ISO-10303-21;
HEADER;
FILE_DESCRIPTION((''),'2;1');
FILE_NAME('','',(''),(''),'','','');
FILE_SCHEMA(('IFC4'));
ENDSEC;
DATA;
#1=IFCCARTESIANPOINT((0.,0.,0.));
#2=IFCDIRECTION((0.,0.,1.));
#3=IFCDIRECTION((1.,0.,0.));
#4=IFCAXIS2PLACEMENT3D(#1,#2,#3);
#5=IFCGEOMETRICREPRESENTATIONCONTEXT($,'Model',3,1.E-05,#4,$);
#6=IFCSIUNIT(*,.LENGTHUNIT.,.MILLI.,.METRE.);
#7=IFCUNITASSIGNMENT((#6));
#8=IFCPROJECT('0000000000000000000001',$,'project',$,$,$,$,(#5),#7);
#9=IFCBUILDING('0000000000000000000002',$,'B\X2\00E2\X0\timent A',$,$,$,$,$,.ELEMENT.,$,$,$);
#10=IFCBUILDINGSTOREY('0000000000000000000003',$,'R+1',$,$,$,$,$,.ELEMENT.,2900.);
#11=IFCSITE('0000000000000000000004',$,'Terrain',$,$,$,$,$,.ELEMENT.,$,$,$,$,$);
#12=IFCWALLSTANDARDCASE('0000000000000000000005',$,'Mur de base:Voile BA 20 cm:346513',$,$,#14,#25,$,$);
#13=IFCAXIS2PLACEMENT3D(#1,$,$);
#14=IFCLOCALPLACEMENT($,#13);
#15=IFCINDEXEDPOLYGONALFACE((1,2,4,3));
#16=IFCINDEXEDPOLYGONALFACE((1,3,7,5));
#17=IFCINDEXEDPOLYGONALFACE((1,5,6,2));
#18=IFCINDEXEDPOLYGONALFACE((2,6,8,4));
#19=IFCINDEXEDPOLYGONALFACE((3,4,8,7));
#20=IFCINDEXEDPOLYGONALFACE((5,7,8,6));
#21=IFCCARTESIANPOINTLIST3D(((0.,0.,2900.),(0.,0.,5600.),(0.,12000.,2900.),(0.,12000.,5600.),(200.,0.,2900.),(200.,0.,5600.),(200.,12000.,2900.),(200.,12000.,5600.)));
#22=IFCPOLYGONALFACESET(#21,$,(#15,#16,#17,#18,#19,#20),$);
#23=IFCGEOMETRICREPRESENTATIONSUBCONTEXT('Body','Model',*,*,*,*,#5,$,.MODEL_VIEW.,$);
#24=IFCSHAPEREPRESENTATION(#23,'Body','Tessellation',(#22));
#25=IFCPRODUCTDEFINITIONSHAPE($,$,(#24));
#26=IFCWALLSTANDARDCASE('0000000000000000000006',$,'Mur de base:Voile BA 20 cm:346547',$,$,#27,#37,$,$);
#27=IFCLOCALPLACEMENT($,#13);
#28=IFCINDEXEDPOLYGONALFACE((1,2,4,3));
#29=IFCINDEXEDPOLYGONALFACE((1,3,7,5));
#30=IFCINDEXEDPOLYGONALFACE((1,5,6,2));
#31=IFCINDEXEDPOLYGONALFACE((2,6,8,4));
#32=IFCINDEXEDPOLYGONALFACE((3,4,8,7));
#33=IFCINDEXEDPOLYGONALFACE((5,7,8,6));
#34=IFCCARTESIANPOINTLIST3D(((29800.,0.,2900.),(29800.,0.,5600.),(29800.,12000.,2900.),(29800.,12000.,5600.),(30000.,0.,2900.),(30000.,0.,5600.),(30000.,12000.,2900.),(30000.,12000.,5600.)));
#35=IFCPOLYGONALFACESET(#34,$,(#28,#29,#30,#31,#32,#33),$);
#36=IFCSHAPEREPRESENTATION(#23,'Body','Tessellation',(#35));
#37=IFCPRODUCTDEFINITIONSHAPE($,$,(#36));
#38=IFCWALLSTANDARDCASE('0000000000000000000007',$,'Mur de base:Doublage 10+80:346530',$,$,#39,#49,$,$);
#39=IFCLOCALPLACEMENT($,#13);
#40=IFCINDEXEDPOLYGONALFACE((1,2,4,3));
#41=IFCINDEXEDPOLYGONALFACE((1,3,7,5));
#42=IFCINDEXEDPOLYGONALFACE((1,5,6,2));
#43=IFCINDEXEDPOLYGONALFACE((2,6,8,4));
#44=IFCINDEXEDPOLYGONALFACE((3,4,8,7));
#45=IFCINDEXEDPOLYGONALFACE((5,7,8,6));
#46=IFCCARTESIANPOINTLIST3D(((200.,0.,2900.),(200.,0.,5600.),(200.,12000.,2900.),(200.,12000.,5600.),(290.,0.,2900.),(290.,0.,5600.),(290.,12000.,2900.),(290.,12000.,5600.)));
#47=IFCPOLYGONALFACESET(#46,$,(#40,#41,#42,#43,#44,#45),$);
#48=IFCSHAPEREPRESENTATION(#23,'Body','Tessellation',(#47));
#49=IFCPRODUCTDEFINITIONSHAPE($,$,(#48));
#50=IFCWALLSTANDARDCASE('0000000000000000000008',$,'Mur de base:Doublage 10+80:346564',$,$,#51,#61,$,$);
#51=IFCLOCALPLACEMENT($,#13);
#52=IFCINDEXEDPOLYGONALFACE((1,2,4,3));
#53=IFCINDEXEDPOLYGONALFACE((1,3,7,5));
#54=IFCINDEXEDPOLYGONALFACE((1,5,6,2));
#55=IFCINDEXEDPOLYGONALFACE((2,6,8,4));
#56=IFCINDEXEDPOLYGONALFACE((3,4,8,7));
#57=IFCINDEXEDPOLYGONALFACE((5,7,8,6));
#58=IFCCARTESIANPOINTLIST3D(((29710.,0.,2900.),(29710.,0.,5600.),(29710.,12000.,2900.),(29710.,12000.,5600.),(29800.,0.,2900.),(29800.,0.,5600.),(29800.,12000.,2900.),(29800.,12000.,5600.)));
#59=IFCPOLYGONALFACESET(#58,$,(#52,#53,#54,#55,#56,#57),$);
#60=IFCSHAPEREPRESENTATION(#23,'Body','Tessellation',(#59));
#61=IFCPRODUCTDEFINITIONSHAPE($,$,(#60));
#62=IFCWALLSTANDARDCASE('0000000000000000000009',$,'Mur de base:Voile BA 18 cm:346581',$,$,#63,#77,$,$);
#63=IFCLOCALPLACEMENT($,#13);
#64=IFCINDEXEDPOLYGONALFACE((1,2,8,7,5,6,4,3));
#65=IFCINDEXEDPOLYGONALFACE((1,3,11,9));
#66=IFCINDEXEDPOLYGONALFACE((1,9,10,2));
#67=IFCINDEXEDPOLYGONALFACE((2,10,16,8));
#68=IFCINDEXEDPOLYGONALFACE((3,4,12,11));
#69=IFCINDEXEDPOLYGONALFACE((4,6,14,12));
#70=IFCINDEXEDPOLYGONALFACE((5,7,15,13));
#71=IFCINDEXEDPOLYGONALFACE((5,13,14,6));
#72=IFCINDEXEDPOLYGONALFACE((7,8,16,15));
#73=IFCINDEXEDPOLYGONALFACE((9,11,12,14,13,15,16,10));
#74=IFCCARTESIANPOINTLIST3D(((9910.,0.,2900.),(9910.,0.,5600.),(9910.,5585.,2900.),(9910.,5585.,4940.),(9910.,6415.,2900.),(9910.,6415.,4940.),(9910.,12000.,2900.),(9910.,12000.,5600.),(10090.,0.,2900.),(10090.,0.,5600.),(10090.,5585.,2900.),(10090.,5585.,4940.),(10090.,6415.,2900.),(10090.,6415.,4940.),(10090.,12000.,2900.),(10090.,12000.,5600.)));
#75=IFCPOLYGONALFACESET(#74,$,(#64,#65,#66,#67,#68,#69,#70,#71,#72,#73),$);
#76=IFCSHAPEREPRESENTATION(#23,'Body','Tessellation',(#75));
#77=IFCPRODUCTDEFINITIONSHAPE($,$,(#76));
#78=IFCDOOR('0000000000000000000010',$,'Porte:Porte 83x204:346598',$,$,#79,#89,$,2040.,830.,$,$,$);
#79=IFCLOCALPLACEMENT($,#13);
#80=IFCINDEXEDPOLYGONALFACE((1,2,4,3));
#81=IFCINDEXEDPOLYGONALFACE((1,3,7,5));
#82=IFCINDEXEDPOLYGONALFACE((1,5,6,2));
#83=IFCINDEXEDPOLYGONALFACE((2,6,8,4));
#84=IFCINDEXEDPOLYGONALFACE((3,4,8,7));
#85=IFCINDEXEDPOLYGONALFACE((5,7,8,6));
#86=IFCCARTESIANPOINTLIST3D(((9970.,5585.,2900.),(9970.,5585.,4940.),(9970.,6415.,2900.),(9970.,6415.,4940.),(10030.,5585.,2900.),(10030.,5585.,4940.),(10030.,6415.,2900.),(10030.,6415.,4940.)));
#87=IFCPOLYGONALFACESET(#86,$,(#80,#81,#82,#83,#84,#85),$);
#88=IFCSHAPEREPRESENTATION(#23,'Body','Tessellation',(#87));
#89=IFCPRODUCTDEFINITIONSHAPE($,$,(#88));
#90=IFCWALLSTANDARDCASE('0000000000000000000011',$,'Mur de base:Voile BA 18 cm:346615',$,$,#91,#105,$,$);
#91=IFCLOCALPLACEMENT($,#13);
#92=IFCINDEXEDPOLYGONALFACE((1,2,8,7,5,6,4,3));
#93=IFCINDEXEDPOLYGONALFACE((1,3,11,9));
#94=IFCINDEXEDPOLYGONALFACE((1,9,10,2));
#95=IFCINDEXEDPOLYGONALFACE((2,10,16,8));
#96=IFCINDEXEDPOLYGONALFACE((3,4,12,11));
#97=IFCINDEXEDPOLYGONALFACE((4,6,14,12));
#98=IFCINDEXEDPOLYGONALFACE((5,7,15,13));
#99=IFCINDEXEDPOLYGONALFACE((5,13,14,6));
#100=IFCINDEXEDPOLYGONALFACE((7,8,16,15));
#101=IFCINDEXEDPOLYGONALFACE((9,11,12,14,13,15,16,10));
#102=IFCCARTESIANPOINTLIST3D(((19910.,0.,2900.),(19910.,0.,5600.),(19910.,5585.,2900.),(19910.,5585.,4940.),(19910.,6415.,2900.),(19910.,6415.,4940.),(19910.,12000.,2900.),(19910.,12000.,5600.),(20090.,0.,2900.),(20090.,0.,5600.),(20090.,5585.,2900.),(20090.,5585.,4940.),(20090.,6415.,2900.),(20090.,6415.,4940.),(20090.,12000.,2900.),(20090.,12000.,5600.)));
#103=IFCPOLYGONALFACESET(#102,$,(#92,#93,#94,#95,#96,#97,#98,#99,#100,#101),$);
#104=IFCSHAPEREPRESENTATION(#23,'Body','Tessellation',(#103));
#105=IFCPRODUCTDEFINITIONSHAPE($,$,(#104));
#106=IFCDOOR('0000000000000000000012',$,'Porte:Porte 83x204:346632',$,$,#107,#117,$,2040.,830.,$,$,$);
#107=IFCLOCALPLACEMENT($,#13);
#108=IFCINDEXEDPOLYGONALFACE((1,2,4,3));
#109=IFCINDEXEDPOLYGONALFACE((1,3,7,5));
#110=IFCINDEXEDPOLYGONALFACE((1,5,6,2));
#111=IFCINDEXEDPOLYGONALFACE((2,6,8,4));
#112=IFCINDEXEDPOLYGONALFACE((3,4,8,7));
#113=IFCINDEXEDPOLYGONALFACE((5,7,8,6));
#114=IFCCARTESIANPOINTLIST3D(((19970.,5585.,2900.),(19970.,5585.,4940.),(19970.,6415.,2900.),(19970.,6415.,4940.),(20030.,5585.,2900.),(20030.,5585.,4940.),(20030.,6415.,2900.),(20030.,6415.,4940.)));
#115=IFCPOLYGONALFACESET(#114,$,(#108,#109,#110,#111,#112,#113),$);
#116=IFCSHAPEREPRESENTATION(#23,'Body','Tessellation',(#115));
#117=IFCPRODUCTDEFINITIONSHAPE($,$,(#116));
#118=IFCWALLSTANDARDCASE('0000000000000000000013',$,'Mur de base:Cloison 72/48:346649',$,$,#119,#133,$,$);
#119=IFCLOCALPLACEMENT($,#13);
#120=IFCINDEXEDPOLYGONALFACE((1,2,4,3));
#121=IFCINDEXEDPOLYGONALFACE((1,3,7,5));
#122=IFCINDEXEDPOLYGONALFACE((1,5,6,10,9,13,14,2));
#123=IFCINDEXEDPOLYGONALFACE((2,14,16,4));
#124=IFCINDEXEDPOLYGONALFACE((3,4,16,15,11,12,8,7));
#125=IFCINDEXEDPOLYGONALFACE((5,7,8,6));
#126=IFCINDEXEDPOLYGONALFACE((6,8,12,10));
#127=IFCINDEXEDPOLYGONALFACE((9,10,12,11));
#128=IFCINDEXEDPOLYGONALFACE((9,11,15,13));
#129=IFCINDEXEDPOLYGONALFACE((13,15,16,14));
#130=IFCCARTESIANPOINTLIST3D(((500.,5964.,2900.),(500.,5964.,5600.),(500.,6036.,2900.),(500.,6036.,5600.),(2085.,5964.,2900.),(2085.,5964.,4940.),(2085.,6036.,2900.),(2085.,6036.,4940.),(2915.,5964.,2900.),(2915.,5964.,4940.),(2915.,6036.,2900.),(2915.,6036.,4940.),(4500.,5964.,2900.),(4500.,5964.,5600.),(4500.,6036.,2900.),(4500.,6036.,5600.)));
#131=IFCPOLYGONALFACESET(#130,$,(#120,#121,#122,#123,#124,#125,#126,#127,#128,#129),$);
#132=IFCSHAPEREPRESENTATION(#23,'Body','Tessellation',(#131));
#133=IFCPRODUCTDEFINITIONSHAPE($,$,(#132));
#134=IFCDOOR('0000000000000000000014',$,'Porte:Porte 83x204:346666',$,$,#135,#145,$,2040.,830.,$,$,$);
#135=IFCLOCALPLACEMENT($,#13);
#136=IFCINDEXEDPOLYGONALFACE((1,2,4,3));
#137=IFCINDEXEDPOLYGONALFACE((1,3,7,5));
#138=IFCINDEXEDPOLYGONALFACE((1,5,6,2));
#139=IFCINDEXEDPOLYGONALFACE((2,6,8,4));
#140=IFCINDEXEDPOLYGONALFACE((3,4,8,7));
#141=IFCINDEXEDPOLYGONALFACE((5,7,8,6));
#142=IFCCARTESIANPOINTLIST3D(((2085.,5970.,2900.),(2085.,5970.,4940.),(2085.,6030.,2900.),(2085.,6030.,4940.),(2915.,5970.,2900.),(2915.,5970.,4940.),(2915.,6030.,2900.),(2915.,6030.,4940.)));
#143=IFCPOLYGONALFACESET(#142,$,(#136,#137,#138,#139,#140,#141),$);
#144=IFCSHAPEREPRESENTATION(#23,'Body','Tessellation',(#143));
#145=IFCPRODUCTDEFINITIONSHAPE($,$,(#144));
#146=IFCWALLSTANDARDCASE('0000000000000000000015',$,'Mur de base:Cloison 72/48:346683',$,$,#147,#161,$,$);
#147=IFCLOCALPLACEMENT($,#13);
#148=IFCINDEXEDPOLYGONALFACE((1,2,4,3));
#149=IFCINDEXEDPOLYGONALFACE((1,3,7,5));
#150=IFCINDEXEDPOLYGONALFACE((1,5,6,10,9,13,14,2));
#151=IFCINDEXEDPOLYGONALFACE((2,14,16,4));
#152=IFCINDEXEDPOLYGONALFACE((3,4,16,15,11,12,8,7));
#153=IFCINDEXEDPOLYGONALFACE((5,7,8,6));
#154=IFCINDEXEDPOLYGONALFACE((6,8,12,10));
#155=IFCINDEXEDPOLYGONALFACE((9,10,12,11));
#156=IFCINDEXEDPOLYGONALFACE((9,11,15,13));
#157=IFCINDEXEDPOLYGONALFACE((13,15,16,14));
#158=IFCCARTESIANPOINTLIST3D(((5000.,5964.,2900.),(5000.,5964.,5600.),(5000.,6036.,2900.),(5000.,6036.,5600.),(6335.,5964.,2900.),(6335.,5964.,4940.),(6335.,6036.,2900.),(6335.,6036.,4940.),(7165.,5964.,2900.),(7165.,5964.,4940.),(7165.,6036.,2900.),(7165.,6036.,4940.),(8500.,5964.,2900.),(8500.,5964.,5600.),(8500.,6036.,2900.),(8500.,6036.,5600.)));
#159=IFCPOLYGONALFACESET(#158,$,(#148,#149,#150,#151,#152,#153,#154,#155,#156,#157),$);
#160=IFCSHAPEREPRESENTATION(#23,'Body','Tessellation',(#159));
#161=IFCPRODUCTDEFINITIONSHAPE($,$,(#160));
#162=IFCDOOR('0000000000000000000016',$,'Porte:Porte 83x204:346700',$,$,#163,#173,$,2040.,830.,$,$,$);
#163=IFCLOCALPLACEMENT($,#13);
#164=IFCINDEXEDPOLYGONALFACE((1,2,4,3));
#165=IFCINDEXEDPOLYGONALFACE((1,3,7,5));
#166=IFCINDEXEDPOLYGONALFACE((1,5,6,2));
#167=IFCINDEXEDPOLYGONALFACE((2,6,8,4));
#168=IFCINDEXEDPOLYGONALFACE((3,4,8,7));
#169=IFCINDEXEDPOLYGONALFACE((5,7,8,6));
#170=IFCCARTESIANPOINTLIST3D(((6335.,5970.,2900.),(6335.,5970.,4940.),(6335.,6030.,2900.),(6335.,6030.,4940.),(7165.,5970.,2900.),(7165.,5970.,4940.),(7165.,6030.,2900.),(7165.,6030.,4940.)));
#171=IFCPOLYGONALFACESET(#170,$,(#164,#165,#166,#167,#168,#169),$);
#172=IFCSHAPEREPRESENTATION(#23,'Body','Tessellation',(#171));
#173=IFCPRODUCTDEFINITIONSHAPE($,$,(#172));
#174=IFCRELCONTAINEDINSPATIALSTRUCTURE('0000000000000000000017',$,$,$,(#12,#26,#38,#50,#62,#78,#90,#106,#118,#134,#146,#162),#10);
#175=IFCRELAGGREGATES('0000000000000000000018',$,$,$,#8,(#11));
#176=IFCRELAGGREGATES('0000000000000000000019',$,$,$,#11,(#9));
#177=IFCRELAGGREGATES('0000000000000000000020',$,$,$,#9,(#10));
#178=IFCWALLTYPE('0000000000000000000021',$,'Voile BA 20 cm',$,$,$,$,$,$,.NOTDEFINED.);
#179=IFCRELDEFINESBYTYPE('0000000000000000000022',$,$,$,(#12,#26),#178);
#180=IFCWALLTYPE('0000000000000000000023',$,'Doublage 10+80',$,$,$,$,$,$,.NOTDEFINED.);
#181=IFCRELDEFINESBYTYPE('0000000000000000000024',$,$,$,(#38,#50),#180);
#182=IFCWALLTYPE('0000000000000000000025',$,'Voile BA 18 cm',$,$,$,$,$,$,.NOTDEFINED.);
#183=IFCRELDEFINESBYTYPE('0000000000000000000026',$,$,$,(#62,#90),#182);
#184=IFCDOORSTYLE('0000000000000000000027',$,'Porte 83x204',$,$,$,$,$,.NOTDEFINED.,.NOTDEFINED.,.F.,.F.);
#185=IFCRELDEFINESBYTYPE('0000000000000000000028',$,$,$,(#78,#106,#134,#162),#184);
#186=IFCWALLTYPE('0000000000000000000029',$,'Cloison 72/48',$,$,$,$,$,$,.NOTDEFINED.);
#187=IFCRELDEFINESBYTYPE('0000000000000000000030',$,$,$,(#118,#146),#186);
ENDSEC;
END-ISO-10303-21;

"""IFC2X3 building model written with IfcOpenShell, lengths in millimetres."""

from ifc_helpers import new_model, si_unit, frame, frame_2d, origin_with_axes, place, context, subcontext, project, spatial, rectangle, extrude, type_object, element, fill, save


model = new_model("IFC2X3")

# Units and contexts
model_context = context("Model", 3, precision=1e-05, world=origin_with_axes())
body_context = subcontext(model_context, "Body", "Model", "MODEL_VIEW")
ifc_project = project(units=[si_unit("LENGTHUNIT", "METRE", prefix="MILLI")], contexts=[model_context])

# Site, building, storey
site = spatial("IfcSite", under=ifc_project, Name="Terrain", CompositionType="ELEMENT")
building = spatial("IfcBuilding", under=site, Name="Bâtiment A", CompositionType="ELEMENT")
storey = spatial("IfcBuildingStorey", under=building, Name="R+1", CompositionType="ELEMENT", Elevation=2900.0)

# Walls
wall_type_1 = type_object("IfcWallType", Name="Voile BA 20 cm", PredefinedType="NOTDEFINED")
wall_1_placement = place(None, origin_with_axes())
element("IfcWallStandardCase", 1, at=wall_1_placement, inside=storey, type_object=wall_type_1, Name="Mur de base:Voile BA 20 cm:346513", context=body_context, shape_type="SweptSolid", body=[
    extrude(rectangle(XDim=200.0, YDim=12000.0, at=frame_2d((100.0, 6000.0))), frame((0.0, 0.0, 2900.0), z_axis=(0.0, 0.0, 1.0), x_axis=(1.0, 0.0, 0.0)), (0.0, 0.0, 1.0), 2700.0),
])
wall_2_placement = place(None, origin_with_axes())
element("IfcWallStandardCase", 2, at=wall_2_placement, inside=storey, type_object=wall_type_1, Name="Mur de base:Voile BA 20 cm:346547", context=body_context, shape_type="SweptSolid", body=[
    extrude(rectangle(XDim=200.0, YDim=12000.0, at=frame_2d((29900.0, 6000.0))), frame((0.0, 0.0, 2900.0), z_axis=(0.0, 0.0, 1.0), x_axis=(1.0, 0.0, 0.0)), (0.0, 0.0, 1.0), 2700.0),
])
wall_type_2 = type_object("IfcWallType", Name="Doublage 10+80", PredefinedType="NOTDEFINED")
wall_3_placement = place(None, origin_with_axes())
element("IfcWallStandardCase", 3, at=wall_3_placement, inside=storey, type_object=wall_type_2, Name="Mur de base:Doublage 10+80:346530", context=body_context, shape_type="SweptSolid", body=[
    extrude(rectangle(XDim=90.0, YDim=12000.0, at=frame_2d((245.0, 6000.0))), frame((0.0, 0.0, 2900.0), z_axis=(0.0, 0.0, 1.0), x_axis=(1.0, 0.0, 0.0)), (0.0, 0.0, 1.0), 2700.0),
])
wall_4_placement = place(None, origin_with_axes())
element("IfcWallStandardCase", 4, at=wall_4_placement, inside=storey, type_object=wall_type_2, Name="Mur de base:Doublage 10+80:346564", context=body_context, shape_type="SweptSolid", body=[
    extrude(rectangle(XDim=90.0, YDim=12000.0, at=frame_2d((29755.0, 6000.0))), frame((0.0, 0.0, 2900.0), z_axis=(0.0, 0.0, 1.0), x_axis=(1.0, 0.0, 0.0)), (0.0, 0.0, 1.0), 2700.0),
])

# Walls, openings, doors
wall_type_3 = type_object("IfcWallType", Name="Voile BA 18 cm", PredefinedType="NOTDEFINED")
wall_5_placement = place(None, origin_with_axes())
wall_5 = element("IfcWallStandardCase", 5, at=wall_5_placement, inside=storey, type_object=wall_type_3, Name="Mur de base:Voile BA 18 cm:346581", context=body_context, shape_type="SweptSolid", body=[
    extrude(rectangle(XDim=180.0, YDim=12000.0, at=frame_2d((10000.0, 6000.0))), frame((0.0, 0.0, 2900.0), z_axis=(0.0, 0.0, 1.0), x_axis=(1.0, 0.0, 0.0)), (0.0, 0.0, 1.0), 2700.0),
])
opening_1_placement = place(None, origin_with_axes())
opening_1 = element("IfcOpeningElement", 6, at=opening_1_placement, cuts=wall_5, context=body_context, shape_type="SweptSolid", body=[
    extrude(rectangle(XDim=300.0, YDim=830.0, at=frame_2d((10000.0, 6000.0))), frame((0.0, 0.0, 2900.0), z_axis=(0.0, 0.0, 1.0), x_axis=(1.0, 0.0, 0.0)), (0.0, 0.0, 1.0), 2040.0),
])
door_style = type_object("IfcDoorStyle", Name="Porte 83x204", ConstructionType="NOTDEFINED", OperationType="NOTDEFINED", ParameterTakesPrecedence=False, Sizeable=False)
door_1_placement = place(None, origin_with_axes())
door_1 = element("IfcDoor", 7, at=door_1_placement, inside=storey, type_object=door_style, Name="Porte:Porte 83x204:346598", OverallHeight=2040.0, OverallWidth=830.0, context=body_context, shape_type="SweptSolid", body=[
    extrude(rectangle(XDim=60.0, YDim=830.0, at=frame_2d((10000.0, 6000.0))), frame((0.0, 0.0, 2900.0), z_axis=(0.0, 0.0, 1.0), x_axis=(1.0, 0.0, 0.0)), (0.0, 0.0, 1.0), 2040.0),
])
fill(opening_1, door_1)
wall_6_placement = place(None, origin_with_axes())
wall_6 = element("IfcWallStandardCase", 8, at=wall_6_placement, inside=storey, type_object=wall_type_3, Name="Mur de base:Voile BA 18 cm:346615", context=body_context, shape_type="SweptSolid", body=[
    extrude(rectangle(XDim=180.0, YDim=12000.0, at=frame_2d((20000.0, 6000.0))), frame((0.0, 0.0, 2900.0), z_axis=(0.0, 0.0, 1.0), x_axis=(1.0, 0.0, 0.0)), (0.0, 0.0, 1.0), 2700.0),
])
opening_2_placement = place(None, origin_with_axes())
opening_2 = element("IfcOpeningElement", 9, at=opening_2_placement, cuts=wall_6, context=body_context, shape_type="SweptSolid", body=[
    extrude(rectangle(XDim=300.0, YDim=830.0, at=frame_2d((20000.0, 6000.0))), frame((0.0, 0.0, 2900.0), z_axis=(0.0, 0.0, 1.0), x_axis=(1.0, 0.0, 0.0)), (0.0, 0.0, 1.0), 2040.0),
])
door_2_placement = place(None, origin_with_axes())
door_2 = element("IfcDoor", 10, at=door_2_placement, inside=storey, type_object=door_style, Name="Porte:Porte 83x204:346632", OverallHeight=2040.0, OverallWidth=830.0, context=body_context, shape_type="SweptSolid", body=[
    extrude(rectangle(XDim=60.0, YDim=830.0, at=frame_2d((20000.0, 6000.0))), frame((0.0, 0.0, 2900.0), z_axis=(0.0, 0.0, 1.0), x_axis=(1.0, 0.0, 0.0)), (0.0, 0.0, 1.0), 2040.0),
])
fill(opening_2, door_2)
wall_type_4 = type_object("IfcWallType", Name="Cloison 72/48", PredefinedType="NOTDEFINED")
wall_7_placement = place(None, origin_with_axes())
wall_7 = element("IfcWallStandardCase", 11, at=wall_7_placement, inside=storey, type_object=wall_type_4, Name="Mur de base:Cloison 72/48:346649", context=body_context, shape_type="SweptSolid", body=[
    extrude(rectangle(XDim=4000.0, YDim=72.0, at=frame_2d((2500.0, 6000.0))), frame((0.0, 0.0, 2900.0), z_axis=(0.0, 0.0, 1.0), x_axis=(1.0, 0.0, 0.0)), (0.0, 0.0, 1.0), 2700.0),
])
opening_3_placement = place(None, origin_with_axes())
opening_3 = element("IfcOpeningElement", 12, at=opening_3_placement, cuts=wall_7, context=body_context, shape_type="SweptSolid", body=[
    extrude(rectangle(XDim=830.0, YDim=192.0, at=frame_2d((2500.0, 6000.0))), frame((0.0, 0.0, 2900.0), z_axis=(0.0, 0.0, 1.0), x_axis=(1.0, 0.0, 0.0)), (0.0, 0.0, 1.0), 2040.0),
])
door_3_placement = place(None, origin_with_axes())
door_3 = element("IfcDoor", 13, at=door_3_placement, inside=storey, type_object=door_style, Name="Porte:Porte 83x204:346666", OverallHeight=2040.0, OverallWidth=830.0, context=body_context, shape_type="SweptSolid", body=[
    extrude(rectangle(XDim=830.0, YDim=60.0, at=frame_2d((2500.0, 6000.0))), frame((0.0, 0.0, 2900.0), z_axis=(0.0, 0.0, 1.0), x_axis=(1.0, 0.0, 0.0)), (0.0, 0.0, 1.0), 2040.0),
])
fill(opening_3, door_3)
wall_8_placement = place(None, origin_with_axes())
wall_8 = element("IfcWallStandardCase", 14, at=wall_8_placement, inside=storey, type_object=wall_type_4, Name="Mur de base:Cloison 72/48:346683", context=body_context, shape_type="SweptSolid", body=[
    extrude(rectangle(XDim=3500.0, YDim=72.0, at=frame_2d((6750.0, 6000.0))), frame((0.0, 0.0, 2900.0), z_axis=(0.0, 0.0, 1.0), x_axis=(1.0, 0.0, 0.0)), (0.0, 0.0, 1.0), 2700.0),
])
opening_4_placement = place(None, origin_with_axes())
opening_4 = element("IfcOpeningElement", 15, at=opening_4_placement, cuts=wall_8, context=body_context, shape_type="SweptSolid", body=[
    extrude(rectangle(XDim=830.0, YDim=192.0, at=frame_2d((6750.0, 6000.0))), frame((0.0, 0.0, 2900.0), z_axis=(0.0, 0.0, 1.0), x_axis=(1.0, 0.0, 0.0)), (0.0, 0.0, 1.0), 2040.0),
])
door_4_placement = place(None, origin_with_axes())
door_4 = element("IfcDoor", 16, at=door_4_placement, inside=storey, type_object=door_style, Name="Porte:Porte 83x204:346700", OverallHeight=2040.0, OverallWidth=830.0, context=body_context, shape_type="SweptSolid", body=[
    extrude(rectangle(XDim=830.0, YDim=60.0, at=frame_2d((6750.0, 6000.0))), frame((0.0, 0.0, 2900.0), z_axis=(0.0, 0.0, 1.0), x_axis=(1.0, 0.0, 0.0)), (0.0, 0.0, 1.0), 2040.0),
])
fill(opening_4, door_4)

save(model, "model.ifc")
